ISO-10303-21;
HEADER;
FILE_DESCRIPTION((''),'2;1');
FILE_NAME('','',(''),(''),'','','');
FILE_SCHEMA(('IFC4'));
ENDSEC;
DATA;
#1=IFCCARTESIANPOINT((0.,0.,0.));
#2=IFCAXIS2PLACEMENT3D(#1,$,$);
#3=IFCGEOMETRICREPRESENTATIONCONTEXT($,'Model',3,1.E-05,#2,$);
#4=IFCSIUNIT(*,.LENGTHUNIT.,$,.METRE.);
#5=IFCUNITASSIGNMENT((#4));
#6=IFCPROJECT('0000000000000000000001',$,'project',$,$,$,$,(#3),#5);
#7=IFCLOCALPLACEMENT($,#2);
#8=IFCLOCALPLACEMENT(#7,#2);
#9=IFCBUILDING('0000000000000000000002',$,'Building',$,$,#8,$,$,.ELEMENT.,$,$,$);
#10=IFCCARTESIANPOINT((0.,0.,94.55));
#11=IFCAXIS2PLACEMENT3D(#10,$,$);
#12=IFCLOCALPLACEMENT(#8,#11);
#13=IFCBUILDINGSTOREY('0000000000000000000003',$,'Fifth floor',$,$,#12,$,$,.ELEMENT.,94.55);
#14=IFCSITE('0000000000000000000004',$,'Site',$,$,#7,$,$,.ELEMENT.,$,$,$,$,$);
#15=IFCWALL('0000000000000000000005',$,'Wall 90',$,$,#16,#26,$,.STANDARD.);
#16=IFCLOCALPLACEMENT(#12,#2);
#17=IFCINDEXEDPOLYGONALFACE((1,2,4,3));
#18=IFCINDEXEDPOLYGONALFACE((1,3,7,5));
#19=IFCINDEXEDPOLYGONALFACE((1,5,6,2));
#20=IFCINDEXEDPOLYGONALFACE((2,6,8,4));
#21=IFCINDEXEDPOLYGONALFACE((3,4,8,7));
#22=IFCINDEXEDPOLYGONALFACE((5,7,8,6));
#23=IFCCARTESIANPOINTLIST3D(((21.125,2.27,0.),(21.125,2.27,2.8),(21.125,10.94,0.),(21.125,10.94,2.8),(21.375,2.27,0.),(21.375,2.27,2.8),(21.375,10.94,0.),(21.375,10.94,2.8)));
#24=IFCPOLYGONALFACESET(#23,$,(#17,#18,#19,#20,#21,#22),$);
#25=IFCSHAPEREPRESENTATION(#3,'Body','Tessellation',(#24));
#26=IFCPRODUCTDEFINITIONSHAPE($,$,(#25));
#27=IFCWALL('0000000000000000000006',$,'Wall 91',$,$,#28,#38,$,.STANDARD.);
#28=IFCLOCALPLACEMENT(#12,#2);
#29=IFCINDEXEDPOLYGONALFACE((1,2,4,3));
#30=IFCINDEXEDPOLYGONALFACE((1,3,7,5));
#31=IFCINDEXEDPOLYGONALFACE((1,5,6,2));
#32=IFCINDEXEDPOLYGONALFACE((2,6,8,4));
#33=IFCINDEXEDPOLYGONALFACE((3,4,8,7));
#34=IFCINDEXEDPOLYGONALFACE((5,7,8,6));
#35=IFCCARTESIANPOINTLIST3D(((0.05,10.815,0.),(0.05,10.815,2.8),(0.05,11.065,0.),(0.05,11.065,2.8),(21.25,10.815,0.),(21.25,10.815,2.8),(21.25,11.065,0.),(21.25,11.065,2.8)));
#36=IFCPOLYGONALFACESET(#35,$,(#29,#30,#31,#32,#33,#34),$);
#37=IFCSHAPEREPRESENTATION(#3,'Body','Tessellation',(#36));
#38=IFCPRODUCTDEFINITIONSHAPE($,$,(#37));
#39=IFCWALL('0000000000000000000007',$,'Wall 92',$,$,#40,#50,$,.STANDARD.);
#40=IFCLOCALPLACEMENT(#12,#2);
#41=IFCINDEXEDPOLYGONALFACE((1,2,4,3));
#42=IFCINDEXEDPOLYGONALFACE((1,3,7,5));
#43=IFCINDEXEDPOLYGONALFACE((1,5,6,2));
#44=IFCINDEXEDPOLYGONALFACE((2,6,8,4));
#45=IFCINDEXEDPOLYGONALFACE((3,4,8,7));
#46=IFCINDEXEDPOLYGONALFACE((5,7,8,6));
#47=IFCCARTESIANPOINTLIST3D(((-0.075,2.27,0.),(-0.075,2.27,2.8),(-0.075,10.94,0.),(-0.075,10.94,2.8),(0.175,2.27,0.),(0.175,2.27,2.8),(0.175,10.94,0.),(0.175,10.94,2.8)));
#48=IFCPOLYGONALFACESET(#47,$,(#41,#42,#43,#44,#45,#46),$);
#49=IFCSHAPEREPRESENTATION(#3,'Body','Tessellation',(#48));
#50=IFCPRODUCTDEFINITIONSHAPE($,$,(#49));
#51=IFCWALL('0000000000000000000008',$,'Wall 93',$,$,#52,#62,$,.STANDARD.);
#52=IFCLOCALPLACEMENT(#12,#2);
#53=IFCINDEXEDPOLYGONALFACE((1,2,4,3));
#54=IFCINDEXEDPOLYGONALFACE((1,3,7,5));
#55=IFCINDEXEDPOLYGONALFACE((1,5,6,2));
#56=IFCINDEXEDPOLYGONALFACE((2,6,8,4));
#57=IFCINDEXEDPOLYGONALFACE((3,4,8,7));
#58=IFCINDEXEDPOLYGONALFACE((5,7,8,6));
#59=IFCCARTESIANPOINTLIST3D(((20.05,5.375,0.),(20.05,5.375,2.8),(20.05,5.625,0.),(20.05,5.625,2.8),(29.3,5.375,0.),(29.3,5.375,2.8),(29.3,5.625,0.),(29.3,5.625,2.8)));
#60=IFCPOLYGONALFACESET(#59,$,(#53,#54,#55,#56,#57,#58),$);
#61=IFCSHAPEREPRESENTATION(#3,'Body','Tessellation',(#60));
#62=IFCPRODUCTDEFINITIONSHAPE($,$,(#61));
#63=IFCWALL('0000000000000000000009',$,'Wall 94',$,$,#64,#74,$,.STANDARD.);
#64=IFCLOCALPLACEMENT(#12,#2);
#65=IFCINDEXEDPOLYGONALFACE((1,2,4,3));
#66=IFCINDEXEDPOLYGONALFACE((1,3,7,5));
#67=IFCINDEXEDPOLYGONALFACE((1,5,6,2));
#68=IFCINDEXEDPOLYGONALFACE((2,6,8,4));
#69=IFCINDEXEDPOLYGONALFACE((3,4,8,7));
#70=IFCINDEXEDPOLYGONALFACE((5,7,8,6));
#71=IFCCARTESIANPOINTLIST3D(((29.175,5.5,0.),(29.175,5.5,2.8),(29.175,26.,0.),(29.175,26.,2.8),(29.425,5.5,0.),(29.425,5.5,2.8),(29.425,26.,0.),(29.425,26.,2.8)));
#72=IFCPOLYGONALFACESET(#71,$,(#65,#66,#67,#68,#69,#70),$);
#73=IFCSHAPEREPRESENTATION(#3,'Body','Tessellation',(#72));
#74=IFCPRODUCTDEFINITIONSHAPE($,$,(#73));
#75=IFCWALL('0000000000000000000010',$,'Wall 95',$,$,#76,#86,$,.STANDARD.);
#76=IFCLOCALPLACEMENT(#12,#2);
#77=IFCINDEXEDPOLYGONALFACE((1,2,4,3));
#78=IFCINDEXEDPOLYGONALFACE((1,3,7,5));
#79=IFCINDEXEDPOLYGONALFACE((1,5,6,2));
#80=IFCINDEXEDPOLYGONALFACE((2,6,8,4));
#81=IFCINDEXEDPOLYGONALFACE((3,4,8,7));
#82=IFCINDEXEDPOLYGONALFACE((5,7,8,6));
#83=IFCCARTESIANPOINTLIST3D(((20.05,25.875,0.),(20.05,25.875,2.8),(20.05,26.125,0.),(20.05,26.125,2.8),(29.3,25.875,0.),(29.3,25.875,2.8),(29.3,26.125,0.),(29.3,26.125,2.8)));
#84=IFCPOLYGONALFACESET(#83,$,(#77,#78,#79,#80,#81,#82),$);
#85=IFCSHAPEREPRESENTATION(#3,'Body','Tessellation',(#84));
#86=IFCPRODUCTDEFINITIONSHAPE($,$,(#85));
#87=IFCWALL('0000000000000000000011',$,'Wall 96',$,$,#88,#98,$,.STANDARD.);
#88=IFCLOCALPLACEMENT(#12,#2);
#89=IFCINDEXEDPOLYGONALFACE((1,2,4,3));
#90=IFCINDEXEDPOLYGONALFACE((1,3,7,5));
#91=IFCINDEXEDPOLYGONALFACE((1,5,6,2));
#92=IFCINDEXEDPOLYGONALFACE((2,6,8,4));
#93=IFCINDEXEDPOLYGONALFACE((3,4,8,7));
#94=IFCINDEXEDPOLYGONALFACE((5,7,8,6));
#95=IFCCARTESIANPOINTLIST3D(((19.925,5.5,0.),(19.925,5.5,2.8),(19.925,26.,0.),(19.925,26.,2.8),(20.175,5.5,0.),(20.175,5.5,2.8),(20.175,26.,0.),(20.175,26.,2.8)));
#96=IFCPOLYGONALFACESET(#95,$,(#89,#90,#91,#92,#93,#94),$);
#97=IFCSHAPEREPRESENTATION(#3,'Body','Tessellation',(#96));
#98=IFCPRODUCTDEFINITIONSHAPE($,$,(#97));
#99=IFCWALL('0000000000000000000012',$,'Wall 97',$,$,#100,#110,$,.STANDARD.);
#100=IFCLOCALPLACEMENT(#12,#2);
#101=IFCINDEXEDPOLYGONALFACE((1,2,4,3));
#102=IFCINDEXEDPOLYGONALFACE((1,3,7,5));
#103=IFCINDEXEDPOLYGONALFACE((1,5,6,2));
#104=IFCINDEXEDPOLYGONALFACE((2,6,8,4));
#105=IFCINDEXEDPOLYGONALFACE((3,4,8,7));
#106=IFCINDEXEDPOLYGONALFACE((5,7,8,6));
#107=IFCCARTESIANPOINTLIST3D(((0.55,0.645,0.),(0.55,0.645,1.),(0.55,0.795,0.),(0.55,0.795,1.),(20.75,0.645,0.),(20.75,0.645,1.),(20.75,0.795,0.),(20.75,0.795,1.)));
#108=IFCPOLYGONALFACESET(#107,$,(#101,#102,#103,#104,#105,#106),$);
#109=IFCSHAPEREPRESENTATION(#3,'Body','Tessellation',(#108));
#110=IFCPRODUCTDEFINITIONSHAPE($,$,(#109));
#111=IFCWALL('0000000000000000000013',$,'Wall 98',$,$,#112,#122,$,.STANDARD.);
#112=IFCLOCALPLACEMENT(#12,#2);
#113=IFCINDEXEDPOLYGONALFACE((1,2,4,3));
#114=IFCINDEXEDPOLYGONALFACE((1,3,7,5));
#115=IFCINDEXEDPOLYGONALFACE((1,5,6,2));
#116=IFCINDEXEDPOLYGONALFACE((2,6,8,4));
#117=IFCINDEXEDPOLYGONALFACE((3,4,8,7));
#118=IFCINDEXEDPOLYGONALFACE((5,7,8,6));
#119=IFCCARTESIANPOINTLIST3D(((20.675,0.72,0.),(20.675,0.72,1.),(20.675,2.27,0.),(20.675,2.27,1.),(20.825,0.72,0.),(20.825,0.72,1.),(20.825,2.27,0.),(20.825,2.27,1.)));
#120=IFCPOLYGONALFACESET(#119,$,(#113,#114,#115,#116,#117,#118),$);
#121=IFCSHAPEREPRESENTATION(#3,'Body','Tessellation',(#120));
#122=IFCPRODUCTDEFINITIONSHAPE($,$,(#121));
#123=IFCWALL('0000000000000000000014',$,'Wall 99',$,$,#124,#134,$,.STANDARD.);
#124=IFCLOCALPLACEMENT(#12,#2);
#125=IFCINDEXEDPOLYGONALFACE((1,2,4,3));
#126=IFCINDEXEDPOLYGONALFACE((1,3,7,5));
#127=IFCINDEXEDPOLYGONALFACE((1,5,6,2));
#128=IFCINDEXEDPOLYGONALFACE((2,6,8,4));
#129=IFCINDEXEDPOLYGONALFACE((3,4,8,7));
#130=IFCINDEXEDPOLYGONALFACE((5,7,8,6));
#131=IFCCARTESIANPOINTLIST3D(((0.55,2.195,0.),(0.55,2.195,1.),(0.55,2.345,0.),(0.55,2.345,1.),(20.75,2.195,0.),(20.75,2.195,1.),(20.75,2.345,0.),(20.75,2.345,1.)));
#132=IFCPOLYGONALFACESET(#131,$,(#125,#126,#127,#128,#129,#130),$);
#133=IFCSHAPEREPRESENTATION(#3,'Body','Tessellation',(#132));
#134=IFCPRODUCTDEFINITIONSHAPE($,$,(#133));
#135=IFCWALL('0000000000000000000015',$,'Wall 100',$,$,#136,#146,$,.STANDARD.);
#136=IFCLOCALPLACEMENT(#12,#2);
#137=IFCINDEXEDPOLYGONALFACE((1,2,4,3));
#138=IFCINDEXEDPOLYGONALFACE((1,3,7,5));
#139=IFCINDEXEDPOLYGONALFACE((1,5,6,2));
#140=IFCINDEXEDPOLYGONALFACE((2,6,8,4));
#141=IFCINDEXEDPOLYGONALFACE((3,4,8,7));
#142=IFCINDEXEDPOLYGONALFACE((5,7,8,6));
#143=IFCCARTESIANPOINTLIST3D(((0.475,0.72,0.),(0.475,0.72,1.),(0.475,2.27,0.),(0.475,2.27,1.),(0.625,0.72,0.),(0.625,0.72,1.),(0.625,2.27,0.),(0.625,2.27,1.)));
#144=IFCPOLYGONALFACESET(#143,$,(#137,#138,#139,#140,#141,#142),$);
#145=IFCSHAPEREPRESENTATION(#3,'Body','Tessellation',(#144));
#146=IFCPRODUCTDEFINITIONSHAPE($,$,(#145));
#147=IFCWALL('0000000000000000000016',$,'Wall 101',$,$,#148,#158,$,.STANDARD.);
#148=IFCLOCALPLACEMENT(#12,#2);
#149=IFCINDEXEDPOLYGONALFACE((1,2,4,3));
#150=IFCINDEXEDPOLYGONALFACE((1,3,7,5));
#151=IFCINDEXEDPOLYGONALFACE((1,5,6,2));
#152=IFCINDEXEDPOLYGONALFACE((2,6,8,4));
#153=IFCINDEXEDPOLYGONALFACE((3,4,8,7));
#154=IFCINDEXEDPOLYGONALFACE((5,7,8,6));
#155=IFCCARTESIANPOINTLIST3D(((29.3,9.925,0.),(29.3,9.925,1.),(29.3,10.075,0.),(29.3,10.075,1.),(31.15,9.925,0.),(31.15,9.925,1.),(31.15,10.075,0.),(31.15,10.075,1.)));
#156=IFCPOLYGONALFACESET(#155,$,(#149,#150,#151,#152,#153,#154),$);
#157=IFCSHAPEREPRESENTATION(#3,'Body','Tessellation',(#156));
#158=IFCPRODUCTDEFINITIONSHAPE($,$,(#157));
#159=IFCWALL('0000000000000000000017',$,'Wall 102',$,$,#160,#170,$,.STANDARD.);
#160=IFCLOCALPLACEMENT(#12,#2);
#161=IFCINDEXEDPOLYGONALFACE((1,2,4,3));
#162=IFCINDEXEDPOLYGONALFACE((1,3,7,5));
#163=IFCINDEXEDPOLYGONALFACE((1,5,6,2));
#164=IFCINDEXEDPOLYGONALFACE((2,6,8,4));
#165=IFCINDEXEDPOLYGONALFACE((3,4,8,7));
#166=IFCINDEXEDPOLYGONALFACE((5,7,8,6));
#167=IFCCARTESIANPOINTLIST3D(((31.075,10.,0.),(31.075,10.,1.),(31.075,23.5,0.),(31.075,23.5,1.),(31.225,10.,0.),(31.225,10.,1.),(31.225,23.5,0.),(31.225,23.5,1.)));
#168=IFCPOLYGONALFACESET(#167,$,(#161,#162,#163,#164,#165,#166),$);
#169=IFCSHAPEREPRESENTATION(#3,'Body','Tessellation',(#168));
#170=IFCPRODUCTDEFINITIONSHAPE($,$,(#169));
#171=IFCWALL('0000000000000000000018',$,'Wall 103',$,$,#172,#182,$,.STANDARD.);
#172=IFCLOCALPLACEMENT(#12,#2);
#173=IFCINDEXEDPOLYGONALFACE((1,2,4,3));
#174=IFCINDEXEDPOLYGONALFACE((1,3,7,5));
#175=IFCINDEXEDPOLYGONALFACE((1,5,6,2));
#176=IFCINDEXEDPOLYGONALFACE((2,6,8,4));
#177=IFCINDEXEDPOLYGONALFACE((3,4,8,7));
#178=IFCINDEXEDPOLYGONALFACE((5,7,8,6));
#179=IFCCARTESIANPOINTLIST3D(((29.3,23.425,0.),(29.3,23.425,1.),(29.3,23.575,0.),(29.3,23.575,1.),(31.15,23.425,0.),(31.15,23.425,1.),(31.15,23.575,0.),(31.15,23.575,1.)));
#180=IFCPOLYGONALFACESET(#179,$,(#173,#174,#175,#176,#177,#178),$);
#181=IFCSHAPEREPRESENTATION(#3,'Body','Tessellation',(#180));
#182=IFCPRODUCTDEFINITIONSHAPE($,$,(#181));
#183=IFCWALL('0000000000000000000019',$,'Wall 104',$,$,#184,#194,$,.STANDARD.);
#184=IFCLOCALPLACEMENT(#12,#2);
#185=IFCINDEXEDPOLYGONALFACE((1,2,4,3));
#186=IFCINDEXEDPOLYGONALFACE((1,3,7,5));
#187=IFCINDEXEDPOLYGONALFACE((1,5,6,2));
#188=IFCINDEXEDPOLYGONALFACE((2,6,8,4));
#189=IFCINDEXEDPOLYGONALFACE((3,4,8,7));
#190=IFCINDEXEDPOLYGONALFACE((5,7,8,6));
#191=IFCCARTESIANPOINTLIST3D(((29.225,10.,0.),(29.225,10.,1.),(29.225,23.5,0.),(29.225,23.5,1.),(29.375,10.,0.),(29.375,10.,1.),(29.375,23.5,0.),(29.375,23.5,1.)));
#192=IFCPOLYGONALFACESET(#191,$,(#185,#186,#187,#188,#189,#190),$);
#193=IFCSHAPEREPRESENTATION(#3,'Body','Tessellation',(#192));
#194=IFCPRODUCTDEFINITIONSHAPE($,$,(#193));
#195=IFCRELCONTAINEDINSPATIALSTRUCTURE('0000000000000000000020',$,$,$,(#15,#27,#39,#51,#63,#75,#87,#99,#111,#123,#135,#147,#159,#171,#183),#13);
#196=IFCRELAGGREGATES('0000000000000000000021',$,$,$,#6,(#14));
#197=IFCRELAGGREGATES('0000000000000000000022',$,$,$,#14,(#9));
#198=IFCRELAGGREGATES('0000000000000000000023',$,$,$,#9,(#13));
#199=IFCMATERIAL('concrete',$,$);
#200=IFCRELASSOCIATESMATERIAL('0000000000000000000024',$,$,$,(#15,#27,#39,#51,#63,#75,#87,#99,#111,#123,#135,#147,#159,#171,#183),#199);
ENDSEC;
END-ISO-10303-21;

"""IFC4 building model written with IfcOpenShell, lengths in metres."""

from ifc_helpers import new_model, si_unit, frame, frame_2d, origin, place, context, project, spatial, rectangle, extrude, material, element, save


model = new_model("IFC4")

# Units and contexts
model_context = context("Model", 3, precision=1e-05, world=origin())
ifc_project = project(units=[si_unit("LENGTHUNIT", "METRE")], contexts=[model_context])

# Site, building, storey
site_placement = place(None, origin())
site = spatial("IfcSite", under=ifc_project, at=site_placement, Name="Site", CompositionType="ELEMENT")
building_placement = place(site_placement, origin())
building = spatial("IfcBuilding", under=site, at=building_placement, Name="Building", CompositionType="ELEMENT")
storey_placement = place(building_placement, frame((0.0, 0.0, 94.55)))
storey = spatial("IfcBuildingStorey", under=building, at=storey_placement, Name="Fifth floor", CompositionType="ELEMENT", Elevation=94.55)

# Shared definitions
ifc_material = material(Name="concrete")

# Walls
wall_1_placement = place(storey_placement, frame((21.25, 2.27, 0.0), z_axis=(0.0, 0.0, 1.0), x_axis=(0.0, 1.0, 0.0)))
element("IfcWall", 1, at=wall_1_placement, inside=storey, material=ifc_material, Name="Wall 90", PredefinedType="STANDARD", context=model_context, shape_type="SweptSolid", body=[
    extrude(rectangle(XDim=8.67, YDim=0.25, at=frame_2d((4.335, 0.0))), origin(), (0.0, 0.0, 1.0), 2.8),
])
wall_2_placement = place(storey_placement, frame((21.25, 10.94, 0.0), z_axis=(0.0, 0.0, 1.0), x_axis=(-1.0, 0.0, 0.0)))
element("IfcWall", 2, at=wall_2_placement, inside=storey, material=ifc_material, Name="Wall 91", PredefinedType="STANDARD", context=model_context, shape_type="SweptSolid", body=[
    extrude(rectangle(XDim=21.2, YDim=0.25, at=frame_2d((10.6, 0.0))), origin(), (0.0, 0.0, 1.0), 2.8),
])
wall_3_placement = place(storey_placement, frame((0.05, 10.94, 0.0), z_axis=(0.0, 0.0, 1.0), x_axis=(0.0, -1.0, 0.0)))
element("IfcWall", 3, at=wall_3_placement, inside=storey, material=ifc_material, Name="Wall 92", PredefinedType="STANDARD", context=model_context, shape_type="SweptSolid", body=[
    extrude(rectangle(XDim=8.67, YDim=0.25, at=frame_2d((4.335, 0.0))), origin(), (0.0, 0.0, 1.0), 2.8),
])
wall_4_placement = place(storey_placement, frame((20.05, 5.5, 0.0), z_axis=(0.0, 0.0, 1.0), x_axis=(1.0, 0.0, 0.0)))
element("IfcWall", 4, at=wall_4_placement, inside=storey, material=ifc_material, Name="Wall 93", PredefinedType="STANDARD", context=model_context, shape_type="SweptSolid", body=[
    extrude(rectangle(XDim=9.25, YDim=0.25, at=frame_2d((4.625, 0.0))), origin(), (0.0, 0.0, 1.0), 2.8),
])
wall_5_placement = place(storey_placement, frame((29.3, 5.5, 0.0), z_axis=(0.0, 0.0, 1.0), x_axis=(0.0, 1.0, 0.0)))
element("IfcWall", 5, at=wall_5_placement, inside=storey, material=ifc_material, Name="Wall 94", PredefinedType="STANDARD", context=model_context, shape_type="SweptSolid", body=[
    extrude(rectangle(XDim=20.5, YDim=0.25, at=frame_2d((10.25, 0.0))), origin(), (0.0, 0.0, 1.0), 2.8),
])
wall_6_placement = place(storey_placement, frame((29.3, 26.0, 0.0), z_axis=(0.0, 0.0, 1.0), x_axis=(-1.0, 0.0, 0.0)))
element("IfcWall", 6, at=wall_6_placement, inside=storey, material=ifc_material, Name="Wall 95", PredefinedType="STANDARD", context=model_context, shape_type="SweptSolid", body=[
    extrude(rectangle(XDim=9.25, YDim=0.25, at=frame_2d((4.625, 0.0))), origin(), (0.0, 0.0, 1.0), 2.8),
])
wall_7_placement = place(storey_placement, frame((20.05, 26.0, 0.0), z_axis=(0.0, 0.0, 1.0), x_axis=(0.0, -1.0, 0.0)))
element("IfcWall", 7, at=wall_7_placement, inside=storey, material=ifc_material, Name="Wall 96", PredefinedType="STANDARD", context=model_context, shape_type="SweptSolid", body=[
    extrude(rectangle(XDim=20.5, YDim=0.25, at=frame_2d((10.25, 0.0))), origin(), (0.0, 0.0, 1.0), 2.8),
])
wall_8_placement = place(storey_placement, frame((0.55, 0.72, 0.0), z_axis=(0.0, 0.0, 1.0), x_axis=(1.0, 0.0, 0.0)))
element("IfcWall", 8, at=wall_8_placement, inside=storey, material=ifc_material, Name="Wall 97", PredefinedType="STANDARD", context=model_context, shape_type="SweptSolid", body=[
    extrude(rectangle(XDim=20.2, YDim=0.15, at=frame_2d((10.1, 0.0))), origin(), (0.0, 0.0, 1.0), 1.0),
])
wall_9_placement = place(storey_placement, frame((20.75, 0.72, 0.0), z_axis=(0.0, 0.0, 1.0), x_axis=(0.0, 1.0, 0.0)))
element("IfcWall", 9, at=wall_9_placement, inside=storey, material=ifc_material, Name="Wall 98", PredefinedType="STANDARD", context=model_context, shape_type="SweptSolid", body=[
    extrude(rectangle(XDim=1.55, YDim=0.15, at=frame_2d((0.775, 0.0))), origin(), (0.0, 0.0, 1.0), 1.0),
])
wall_10_placement = place(storey_placement, frame((20.75, 2.27, 0.0), z_axis=(0.0, 0.0, 1.0), x_axis=(-1.0, 0.0, 0.0)))
element("IfcWall", 10, at=wall_10_placement, inside=storey, material=ifc_material, Name="Wall 99", PredefinedType="STANDARD", context=model_context, shape_type="SweptSolid", body=[
    extrude(rectangle(XDim=20.2, YDim=0.15, at=frame_2d((10.1, 0.0))), origin(), (0.0, 0.0, 1.0), 1.0),
])
wall_11_placement = place(storey_placement, frame((0.55, 2.27, 0.0), z_axis=(0.0, 0.0, 1.0), x_axis=(0.0, -1.0, 0.0)))
element("IfcWall", 11, at=wall_11_placement, inside=storey, material=ifc_material, Name="Wall 100", PredefinedType="STANDARD", context=model_context, shape_type="SweptSolid", body=[
    extrude(rectangle(XDim=1.55, YDim=0.15, at=frame_2d((0.775, 0.0))), origin(), (0.0, 0.0, 1.0), 1.0),
])
wall_12_placement = place(storey_placement, frame((29.3, 10.0, 0.0), z_axis=(0.0, 0.0, 1.0), x_axis=(1.0, 0.0, 0.0)))
element("IfcWall", 12, at=wall_12_placement, inside=storey, material=ifc_material, Name="Wall 101", PredefinedType="STANDARD", context=model_context, shape_type="SweptSolid", body=[
    extrude(rectangle(XDim=1.85, YDim=0.15, at=frame_2d((0.925, 0.0))), origin(), (0.0, 0.0, 1.0), 1.0),
])
wall_13_placement = place(storey_placement, frame((31.15, 10.0, 0.0), z_axis=(0.0, 0.0, 1.0), x_axis=(0.0, 1.0, 0.0)))
element("IfcWall", 13, at=wall_13_placement, inside=storey, material=ifc_material, Name="Wall 102", PredefinedType="STANDARD", context=model_context, shape_type="SweptSolid", body=[
    extrude(rectangle(XDim=13.5, YDim=0.15, at=frame_2d((6.75, 0.0))), origin(), (0.0, 0.0, 1.0), 1.0),
])
wall_14_placement = place(storey_placement, frame((31.15, 23.5, 0.0), z_axis=(0.0, 0.0, 1.0), x_axis=(-1.0, 0.0, 0.0)))
element("IfcWall", 14, at=wall_14_placement, inside=storey, material=ifc_material, Name="Wall 103", PredefinedType="STANDARD", context=model_context, shape_type="SweptSolid", body=[
    extrude(rectangle(XDim=1.85, YDim=0.15, at=frame_2d((0.925, 0.0))), origin(), (0.0, 0.0, 1.0), 1.0),
])
wall_15_placement = place(storey_placement, frame((29.3, 23.5, 0.0), z_axis=(0.0, 0.0, 1.0), x_axis=(0.0, -1.0, 0.0)))
element("IfcWall", 15, at=wall_15_placement, inside=storey, material=ifc_material, Name="Wall 104", PredefinedType="STANDARD", context=model_context, shape_type="SweptSolid", body=[
    extrude(rectangle(XDim=13.5, YDim=0.15, at=frame_2d((6.75, 0.0))), origin(), (0.0, 0.0, 1.0), 1.0),
])

save(model, "model.ifc")
